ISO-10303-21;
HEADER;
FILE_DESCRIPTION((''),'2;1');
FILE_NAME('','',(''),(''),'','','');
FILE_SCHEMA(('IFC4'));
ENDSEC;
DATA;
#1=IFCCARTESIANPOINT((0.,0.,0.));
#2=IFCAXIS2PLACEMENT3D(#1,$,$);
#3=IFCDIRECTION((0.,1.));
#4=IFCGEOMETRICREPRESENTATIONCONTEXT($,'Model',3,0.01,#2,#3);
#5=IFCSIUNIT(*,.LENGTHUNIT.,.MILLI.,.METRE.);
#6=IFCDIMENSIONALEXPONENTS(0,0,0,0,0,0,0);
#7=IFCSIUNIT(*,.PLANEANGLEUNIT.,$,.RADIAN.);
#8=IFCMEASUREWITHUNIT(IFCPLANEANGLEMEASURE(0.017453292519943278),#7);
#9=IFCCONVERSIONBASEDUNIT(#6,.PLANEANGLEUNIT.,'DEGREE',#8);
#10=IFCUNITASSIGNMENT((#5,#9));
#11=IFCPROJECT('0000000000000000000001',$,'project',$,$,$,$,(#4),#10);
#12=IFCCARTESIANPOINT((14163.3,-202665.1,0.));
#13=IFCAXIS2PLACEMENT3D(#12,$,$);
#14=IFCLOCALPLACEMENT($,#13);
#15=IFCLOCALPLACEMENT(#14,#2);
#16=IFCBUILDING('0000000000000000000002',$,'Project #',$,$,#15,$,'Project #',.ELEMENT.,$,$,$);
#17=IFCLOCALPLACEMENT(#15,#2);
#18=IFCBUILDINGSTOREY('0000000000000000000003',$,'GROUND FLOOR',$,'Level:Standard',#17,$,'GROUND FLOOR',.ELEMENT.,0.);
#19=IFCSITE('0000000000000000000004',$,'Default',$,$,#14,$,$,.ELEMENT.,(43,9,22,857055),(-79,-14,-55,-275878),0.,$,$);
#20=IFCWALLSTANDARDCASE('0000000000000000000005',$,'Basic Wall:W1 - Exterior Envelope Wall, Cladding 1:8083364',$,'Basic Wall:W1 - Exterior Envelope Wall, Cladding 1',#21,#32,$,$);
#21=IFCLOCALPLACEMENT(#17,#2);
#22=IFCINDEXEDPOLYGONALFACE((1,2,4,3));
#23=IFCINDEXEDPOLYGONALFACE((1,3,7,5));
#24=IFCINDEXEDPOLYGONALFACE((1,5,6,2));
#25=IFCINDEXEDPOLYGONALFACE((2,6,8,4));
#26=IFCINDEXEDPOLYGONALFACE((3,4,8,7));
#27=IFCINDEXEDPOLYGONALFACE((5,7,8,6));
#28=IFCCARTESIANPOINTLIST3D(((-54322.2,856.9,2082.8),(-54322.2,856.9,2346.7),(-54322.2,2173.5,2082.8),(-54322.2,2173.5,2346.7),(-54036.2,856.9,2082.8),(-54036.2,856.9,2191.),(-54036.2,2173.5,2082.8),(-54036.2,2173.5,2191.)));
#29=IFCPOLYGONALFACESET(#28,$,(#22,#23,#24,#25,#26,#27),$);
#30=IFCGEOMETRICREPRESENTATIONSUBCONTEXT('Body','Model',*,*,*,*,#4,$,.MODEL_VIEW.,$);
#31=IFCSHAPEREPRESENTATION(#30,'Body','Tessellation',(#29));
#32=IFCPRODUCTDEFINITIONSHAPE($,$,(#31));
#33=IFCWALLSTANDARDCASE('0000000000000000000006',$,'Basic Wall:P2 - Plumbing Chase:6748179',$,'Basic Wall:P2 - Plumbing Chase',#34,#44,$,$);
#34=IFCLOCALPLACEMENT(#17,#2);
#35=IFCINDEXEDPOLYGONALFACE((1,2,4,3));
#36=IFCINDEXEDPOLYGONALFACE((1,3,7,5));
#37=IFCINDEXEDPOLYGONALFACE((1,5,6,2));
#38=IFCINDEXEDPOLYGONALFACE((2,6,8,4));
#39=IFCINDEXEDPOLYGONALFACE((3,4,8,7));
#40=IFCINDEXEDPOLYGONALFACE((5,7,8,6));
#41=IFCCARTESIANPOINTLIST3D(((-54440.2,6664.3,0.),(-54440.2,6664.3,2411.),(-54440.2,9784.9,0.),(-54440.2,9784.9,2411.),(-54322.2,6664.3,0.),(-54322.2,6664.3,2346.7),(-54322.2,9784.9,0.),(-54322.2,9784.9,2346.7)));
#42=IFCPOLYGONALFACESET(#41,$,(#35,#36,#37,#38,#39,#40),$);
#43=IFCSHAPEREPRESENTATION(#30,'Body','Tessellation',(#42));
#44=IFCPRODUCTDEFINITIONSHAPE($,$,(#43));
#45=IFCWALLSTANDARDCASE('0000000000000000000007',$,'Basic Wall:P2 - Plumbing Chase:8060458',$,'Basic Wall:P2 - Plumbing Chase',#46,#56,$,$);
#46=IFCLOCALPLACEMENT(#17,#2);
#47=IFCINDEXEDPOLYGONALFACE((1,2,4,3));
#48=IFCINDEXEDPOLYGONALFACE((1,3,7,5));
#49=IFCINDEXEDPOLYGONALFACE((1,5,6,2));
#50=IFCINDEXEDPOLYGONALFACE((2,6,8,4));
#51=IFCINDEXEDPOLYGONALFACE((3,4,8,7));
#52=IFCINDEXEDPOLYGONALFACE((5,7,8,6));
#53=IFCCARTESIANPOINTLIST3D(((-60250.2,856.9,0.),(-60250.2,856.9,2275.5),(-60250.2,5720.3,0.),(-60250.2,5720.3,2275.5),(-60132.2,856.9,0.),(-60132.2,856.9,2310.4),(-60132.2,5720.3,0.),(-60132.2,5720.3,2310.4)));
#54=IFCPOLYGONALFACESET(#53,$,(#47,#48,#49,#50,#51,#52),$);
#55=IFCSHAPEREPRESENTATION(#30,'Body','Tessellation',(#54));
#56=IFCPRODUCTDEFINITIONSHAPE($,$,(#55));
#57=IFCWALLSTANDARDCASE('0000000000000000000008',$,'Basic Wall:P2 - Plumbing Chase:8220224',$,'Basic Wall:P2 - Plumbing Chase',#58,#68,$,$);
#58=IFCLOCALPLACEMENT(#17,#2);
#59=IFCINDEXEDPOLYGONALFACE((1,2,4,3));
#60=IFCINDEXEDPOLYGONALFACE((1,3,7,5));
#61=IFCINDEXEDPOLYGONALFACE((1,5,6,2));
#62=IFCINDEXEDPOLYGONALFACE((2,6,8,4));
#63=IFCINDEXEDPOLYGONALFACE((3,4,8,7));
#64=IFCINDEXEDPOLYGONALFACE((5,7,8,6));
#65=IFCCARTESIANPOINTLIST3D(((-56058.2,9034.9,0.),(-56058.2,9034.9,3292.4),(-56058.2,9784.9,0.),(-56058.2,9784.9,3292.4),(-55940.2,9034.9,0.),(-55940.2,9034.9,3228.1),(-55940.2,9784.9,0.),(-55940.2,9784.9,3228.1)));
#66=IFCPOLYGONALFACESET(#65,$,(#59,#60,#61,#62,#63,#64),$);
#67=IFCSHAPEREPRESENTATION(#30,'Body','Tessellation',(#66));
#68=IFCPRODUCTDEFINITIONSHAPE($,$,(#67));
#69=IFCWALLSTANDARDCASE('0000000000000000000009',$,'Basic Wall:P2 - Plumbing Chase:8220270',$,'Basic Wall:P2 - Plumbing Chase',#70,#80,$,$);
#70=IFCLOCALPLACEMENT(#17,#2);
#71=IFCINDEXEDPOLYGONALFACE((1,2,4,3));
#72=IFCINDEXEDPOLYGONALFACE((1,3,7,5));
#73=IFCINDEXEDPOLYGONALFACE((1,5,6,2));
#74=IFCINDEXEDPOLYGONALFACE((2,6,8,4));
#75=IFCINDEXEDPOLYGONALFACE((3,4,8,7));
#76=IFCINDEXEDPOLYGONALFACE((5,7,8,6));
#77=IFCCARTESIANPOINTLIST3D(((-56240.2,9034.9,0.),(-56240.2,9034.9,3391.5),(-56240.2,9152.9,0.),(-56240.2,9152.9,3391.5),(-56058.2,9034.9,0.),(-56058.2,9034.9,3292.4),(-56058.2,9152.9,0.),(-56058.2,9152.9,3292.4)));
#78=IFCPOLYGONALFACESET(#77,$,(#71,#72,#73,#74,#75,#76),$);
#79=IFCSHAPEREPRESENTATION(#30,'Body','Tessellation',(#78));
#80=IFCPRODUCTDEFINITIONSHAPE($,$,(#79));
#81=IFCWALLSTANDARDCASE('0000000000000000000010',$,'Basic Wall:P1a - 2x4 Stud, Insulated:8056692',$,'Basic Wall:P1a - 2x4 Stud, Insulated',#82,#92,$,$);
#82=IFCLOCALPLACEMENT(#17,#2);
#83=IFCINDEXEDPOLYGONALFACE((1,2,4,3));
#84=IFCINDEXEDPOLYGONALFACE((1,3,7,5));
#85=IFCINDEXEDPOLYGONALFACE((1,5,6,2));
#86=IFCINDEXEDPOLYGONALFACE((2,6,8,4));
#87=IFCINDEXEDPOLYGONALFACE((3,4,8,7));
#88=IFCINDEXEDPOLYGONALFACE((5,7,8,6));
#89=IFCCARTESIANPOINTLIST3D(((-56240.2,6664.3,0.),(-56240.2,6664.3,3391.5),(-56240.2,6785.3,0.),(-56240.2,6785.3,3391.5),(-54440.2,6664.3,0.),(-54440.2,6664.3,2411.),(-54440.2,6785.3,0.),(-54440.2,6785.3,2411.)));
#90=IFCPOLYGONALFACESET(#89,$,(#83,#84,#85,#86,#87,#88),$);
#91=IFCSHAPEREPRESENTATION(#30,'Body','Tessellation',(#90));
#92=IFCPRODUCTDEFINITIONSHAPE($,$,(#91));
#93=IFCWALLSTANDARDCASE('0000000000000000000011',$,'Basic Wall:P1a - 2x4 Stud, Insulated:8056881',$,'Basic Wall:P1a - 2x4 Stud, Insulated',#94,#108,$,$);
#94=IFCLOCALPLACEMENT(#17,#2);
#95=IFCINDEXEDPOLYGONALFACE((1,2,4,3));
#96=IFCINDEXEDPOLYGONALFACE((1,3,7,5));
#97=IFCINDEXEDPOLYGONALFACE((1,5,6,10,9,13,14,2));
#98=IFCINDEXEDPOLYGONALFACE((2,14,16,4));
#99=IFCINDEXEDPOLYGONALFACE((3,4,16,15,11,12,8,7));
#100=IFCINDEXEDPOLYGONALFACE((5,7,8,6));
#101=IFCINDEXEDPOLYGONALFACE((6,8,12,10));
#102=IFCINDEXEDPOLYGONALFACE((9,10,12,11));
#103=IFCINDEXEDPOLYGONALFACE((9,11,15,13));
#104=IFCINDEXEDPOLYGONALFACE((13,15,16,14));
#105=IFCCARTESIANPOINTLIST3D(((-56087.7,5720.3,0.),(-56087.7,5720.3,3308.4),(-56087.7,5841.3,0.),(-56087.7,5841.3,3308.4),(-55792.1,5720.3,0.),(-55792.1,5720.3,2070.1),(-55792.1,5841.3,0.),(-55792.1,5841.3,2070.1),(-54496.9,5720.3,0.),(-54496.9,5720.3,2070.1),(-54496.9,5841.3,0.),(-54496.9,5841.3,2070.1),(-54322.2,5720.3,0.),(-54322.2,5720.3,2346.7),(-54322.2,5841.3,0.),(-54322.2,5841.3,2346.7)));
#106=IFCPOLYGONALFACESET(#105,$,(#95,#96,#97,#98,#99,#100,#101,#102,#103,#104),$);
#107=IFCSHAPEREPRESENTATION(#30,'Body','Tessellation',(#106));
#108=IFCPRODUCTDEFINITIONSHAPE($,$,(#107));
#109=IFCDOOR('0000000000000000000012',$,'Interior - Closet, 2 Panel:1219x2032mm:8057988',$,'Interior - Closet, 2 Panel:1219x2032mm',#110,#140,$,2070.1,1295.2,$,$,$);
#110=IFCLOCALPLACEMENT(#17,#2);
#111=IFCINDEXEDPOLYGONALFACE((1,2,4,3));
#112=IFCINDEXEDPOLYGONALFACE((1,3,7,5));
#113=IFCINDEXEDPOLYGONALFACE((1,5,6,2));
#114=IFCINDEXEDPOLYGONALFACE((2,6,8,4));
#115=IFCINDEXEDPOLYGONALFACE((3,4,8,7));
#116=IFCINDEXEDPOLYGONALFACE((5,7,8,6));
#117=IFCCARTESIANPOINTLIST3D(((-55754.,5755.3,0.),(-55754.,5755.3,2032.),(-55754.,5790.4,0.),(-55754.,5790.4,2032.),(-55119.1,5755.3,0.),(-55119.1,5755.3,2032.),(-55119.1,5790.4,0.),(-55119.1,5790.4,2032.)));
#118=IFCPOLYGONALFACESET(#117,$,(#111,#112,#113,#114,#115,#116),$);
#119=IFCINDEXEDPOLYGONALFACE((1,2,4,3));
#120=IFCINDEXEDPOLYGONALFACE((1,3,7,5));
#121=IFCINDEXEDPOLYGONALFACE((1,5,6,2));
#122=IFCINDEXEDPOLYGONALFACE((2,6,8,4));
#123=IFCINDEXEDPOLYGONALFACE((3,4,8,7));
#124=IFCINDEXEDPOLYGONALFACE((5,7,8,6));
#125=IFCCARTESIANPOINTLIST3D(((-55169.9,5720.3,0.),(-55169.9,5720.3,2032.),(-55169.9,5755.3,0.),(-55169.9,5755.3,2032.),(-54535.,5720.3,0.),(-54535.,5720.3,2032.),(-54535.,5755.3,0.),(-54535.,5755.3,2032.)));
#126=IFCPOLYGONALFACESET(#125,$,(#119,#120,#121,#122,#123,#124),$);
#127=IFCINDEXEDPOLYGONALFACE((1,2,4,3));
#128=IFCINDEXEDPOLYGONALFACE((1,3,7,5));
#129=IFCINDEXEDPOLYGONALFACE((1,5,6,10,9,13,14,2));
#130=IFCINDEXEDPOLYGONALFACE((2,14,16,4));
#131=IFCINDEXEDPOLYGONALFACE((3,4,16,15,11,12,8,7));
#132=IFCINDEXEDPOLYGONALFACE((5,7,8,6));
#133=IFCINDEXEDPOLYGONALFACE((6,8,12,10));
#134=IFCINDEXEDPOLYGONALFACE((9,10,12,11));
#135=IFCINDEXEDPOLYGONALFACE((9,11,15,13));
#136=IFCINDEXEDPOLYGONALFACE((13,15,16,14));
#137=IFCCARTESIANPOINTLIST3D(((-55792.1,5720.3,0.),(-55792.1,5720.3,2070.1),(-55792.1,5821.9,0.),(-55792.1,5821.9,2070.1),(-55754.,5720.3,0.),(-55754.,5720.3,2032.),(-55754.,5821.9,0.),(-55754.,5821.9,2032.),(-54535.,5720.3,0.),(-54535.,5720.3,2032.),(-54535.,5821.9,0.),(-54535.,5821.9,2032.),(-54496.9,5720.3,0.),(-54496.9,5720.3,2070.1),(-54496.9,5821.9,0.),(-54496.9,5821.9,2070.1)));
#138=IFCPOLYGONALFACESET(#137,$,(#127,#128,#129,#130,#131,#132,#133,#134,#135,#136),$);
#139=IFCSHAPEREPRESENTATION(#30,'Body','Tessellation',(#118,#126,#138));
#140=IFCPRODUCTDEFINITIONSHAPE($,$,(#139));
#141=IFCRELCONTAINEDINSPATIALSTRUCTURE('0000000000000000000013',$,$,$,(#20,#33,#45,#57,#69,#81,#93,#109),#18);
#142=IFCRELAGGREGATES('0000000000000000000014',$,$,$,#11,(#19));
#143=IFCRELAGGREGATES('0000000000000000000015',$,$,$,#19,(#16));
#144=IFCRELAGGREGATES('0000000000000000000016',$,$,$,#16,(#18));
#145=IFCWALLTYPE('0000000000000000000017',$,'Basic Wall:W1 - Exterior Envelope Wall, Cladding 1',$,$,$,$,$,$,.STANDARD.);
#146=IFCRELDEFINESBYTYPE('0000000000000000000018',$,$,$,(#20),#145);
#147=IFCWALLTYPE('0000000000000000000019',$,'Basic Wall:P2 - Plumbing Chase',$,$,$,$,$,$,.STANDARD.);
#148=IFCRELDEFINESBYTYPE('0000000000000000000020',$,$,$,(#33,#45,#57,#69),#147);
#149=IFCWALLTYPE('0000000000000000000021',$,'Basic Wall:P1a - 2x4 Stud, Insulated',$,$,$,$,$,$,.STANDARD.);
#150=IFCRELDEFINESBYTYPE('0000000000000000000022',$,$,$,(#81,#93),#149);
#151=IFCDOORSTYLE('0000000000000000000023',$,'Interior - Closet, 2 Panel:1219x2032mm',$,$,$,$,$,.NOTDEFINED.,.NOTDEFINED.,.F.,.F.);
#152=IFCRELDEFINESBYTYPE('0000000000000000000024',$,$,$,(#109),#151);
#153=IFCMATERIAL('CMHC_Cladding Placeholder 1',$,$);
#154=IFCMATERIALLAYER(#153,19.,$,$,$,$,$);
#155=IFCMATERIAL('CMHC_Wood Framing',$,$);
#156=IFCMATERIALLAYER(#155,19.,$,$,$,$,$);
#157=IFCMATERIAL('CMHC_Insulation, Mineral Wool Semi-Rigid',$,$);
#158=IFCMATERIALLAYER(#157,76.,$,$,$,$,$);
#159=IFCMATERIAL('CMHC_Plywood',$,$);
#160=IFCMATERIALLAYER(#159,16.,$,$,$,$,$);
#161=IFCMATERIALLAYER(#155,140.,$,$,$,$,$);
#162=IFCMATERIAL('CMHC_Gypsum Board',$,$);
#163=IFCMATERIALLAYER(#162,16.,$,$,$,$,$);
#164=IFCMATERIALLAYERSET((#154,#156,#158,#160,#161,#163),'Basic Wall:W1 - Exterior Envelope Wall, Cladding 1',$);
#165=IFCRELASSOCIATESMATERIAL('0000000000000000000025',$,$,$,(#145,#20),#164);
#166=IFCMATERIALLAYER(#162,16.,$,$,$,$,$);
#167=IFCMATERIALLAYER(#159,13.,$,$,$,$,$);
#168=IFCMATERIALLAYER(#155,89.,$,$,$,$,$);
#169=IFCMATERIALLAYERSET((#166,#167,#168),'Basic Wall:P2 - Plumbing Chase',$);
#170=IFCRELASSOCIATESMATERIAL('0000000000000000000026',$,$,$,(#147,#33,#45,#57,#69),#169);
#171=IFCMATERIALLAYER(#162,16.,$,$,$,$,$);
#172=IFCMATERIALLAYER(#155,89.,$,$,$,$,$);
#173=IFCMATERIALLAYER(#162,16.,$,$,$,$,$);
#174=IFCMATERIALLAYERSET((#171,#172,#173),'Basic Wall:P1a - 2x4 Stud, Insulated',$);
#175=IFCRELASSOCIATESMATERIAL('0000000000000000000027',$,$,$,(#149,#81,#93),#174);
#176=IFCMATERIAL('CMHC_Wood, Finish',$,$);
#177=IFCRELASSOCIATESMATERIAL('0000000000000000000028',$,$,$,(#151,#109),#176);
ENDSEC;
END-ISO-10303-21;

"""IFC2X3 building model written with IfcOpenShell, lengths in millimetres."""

from ifc_helpers import new_model, entity, si_unit, converted_unit, direction, frame, frame_2d, origin, place, context, subcontext, project, spatial, polyline, rectangle, outline, extrude, clip, bounded_halfspace, source, transform, mapped, material, layer, layer_set, layer_usage, type_object, type_shapes, element, fill, save


model = new_model("IFC2X3")

# Units and contexts
model_context = context("Model", 3, precision=0.01, world=origin(), true_north=direction((0.0, 1.0)))
body_context = subcontext(model_context, "Body", "Model", "MODEL_VIEW")
ifc_project = project(units=[si_unit("LENGTHUNIT", "METRE", prefix="MILLI"), converted_unit("PLANEANGLEUNIT", "DEGREE", entity("IfcPlaneAngleMeasure", 0.017453292519943278), si_unit("PLANEANGLEUNIT", "RADIAN"), dimensions=[0, 0, 0, 0, 0, 0, 0])], contexts=[model_context])

# Site, building, storey
site_placement = place(None, frame((14163.3, -202665.1, 0.0)))
site = spatial("IfcSite", under=ifc_project, at=site_placement, Name="Default", CompositionType="ELEMENT", RefLatitude=(43, 9, 22, 857055), RefLongitude=(-79, -14, -55, -275878), RefElevation=0.0)
building_placement = place(site_placement, origin())
building = spatial("IfcBuilding", under=site, at=building_placement, Name="Project #", LongName="Project #", CompositionType="ELEMENT")
storey_placement = place(building_placement, origin())
storey = spatial("IfcBuildingStorey", under=building, at=storey_placement, Name="GROUND FLOOR", ObjectType="Level:Standard", LongName="GROUND FLOOR", CompositionType="ELEMENT", Elevation=0.0)

# Shared definitions
ifc_material_1 = material(Name="CMHC_Cladding Placeholder 1")
ifc_layer_1 = layer(ifc_material_1, 19.0)
ifc_material_2 = material(Name="CMHC_Wood Framing")
ifc_layer_2 = layer(ifc_material_2, 19.0)
ifc_material_3 = material(Name="CMHC_Insulation, Mineral Wool Semi-Rigid")
ifc_layer_3 = layer(ifc_material_3, 76.0)
ifc_material_4 = material(Name="CMHC_Plywood")
ifc_layer_4 = layer(ifc_material_4, 16.0)
ifc_layer_5 = layer(ifc_material_2, 140.0)
ifc_material_5 = material(Name="CMHC_Gypsum Board")
ifc_layer_6 = layer(ifc_material_5, 16.0)
ifc_layer_set_1 = layer_set([ifc_layer_1, ifc_layer_2, ifc_layer_3, ifc_layer_4, ifc_layer_5, ifc_layer_6], Name="Basic Wall:W1 - Exterior Envelope Wall, Cladding 1")
wall_type_1 = type_object("IfcWallType", Name="Basic Wall:W1 - Exterior Envelope Wall, Cladding 1", PredefinedType="STANDARD", material=ifc_layer_set_1)

# Walls
ifc_layer_usage_1 = layer_usage(ifc_layer_set_1, "AXIS2", "POSITIVE", -143.0)
wall_1_placement = place(storey_placement, frame((-54179.2, 856.9, 2082.8), z_axis=(0.0, 0.0, 1.0), x_axis=(0.0, 1.0, 0.0)))
element("IfcWallStandardCase", 1, at=wall_1_placement, inside=storey, type_object=wall_type_1, material=ifc_layer_usage_1, Name="Basic Wall:W1 - Exterior Envelope Wall, Cladding 1:8083364", ObjectType="Basic Wall:W1 - Exterior Envelope Wall, Cladding 1", context=body_context, shape_type="Clipping", body=[
    clip(extrude(rectangle(XDim=1316.6, YDim=286.0, at=frame_2d((658.3, 0.0), x_axis=(-1.0, 0.0))), origin(), (0.0, 0.0, 1.0), 263.9), bounded_halfspace(frame((0.0, -143.0, 108.2), z_axis=(0.0, -0.478352, 0.878168), x_axis=(1.0, 0.0, 0.0)), False, frame((0.0, -143.0, 108.2)), polyline([(0.0, 0.0), (1316.6, 0.0), (1316.6, 286.0), (0.0, 286.0), (0.0, 0.0)]))),
])
ifc_layer_7 = layer(ifc_material_5, 16.0)
ifc_layer_8 = layer(ifc_material_4, 13.0)
ifc_layer_9 = layer(ifc_material_2, 89.0)
ifc_layer_set_2 = layer_set([ifc_layer_7, ifc_layer_8, ifc_layer_9], Name="Basic Wall:P2 - Plumbing Chase")
ifc_layer_usage_2 = layer_usage(ifc_layer_set_2, "AXIS2", "POSITIVE", -59.0)
wall_type_2 = type_object("IfcWallType", Name="Basic Wall:P2 - Plumbing Chase", PredefinedType="STANDARD", material=ifc_layer_set_2)
wall_2_placement = place(storey_placement, frame((-54381.2, 9784.9, 0.0), z_axis=(0.0, 0.0, 1.0), x_axis=(0.0, -1.0, 0.0)))
element("IfcWallStandardCase", 2, at=wall_2_placement, inside=storey, type_object=wall_type_2, material=ifc_layer_usage_2, Name="Basic Wall:P2 - Plumbing Chase:6748179", ObjectType="Basic Wall:P2 - Plumbing Chase", context=body_context, shape_type="Clipping", body=[
    clip(extrude(rectangle(XDim=3120.6, YDim=118.0, at=frame_2d((1560.3, 0.0), x_axis=(-1.0, 0.0))), origin(), (0.0, 0.0, 1.0), 2411.0), bounded_halfspace(frame((0.0, -59.0, 2411.0), z_axis=(0.0, 0.478352, 0.878168), x_axis=(-1.0, 0.0, 0.0)), False, frame((0.0, -59.0, 2411.0)), polyline([(0.0, 0.0), (2999.6, 0.0), (3120.6, 0.0), (3120.6, 118.0), (0.0, 118.0), (0.0, 0.0)]))),
])
ifc_layer_usage_3 = layer_usage(ifc_layer_set_2, "AXIS2", "NEGATIVE", 59.0)
wall_3_placement = place(storey_placement, frame((-60191.2, 5720.3, 0.0), z_axis=(0.0, 0.0, 1.0), x_axis=(0.0, -1.0, 0.0)))
element("IfcWallStandardCase", 3, at=wall_3_placement, inside=storey, type_object=wall_type_2, material=ifc_layer_usage_3, Name="Basic Wall:P2 - Plumbing Chase:8060458", ObjectType="Basic Wall:P2 - Plumbing Chase", context=body_context, shape_type="Clipping", body=[
    clip(extrude(rectangle(XDim=4863.4, YDim=118.0, at=frame_2d((2431.7, 0.0), x_axis=(-1.0, 0.0))), origin(), (0.0, 0.0, 1.0), 2310.4), bounded_halfspace(frame((0.0, -59.0, 2275.5), z_axis=(0.0, -0.283519, 0.958967), x_axis=(1.0, 0.0, 0.0)), False, frame((0.0, -59.0, 2275.5)), polyline([(0.0, 0.0), (4863.4, 0.0), (4863.4, 118.0), (0.0, 118.0), (0.0, 0.0)]))),
])
ifc_layer_usage_4 = layer_usage(ifc_layer_set_2, "AXIS2", "POSITIVE", -59.0)
wall_4_placement = place(storey_placement, frame((-55999.2, 9034.9, 0.0), z_axis=(0.0, 0.0, 1.0), x_axis=(0.0, 1.0, 0.0)))
element("IfcWallStandardCase", 4, at=wall_4_placement, inside=storey, type_object=wall_type_2, material=ifc_layer_usage_4, Name="Basic Wall:P2 - Plumbing Chase:8220224", ObjectType="Basic Wall:P2 - Plumbing Chase", context=body_context, shape_type="Clipping", body=[
    clip(extrude(rectangle(XDim=750.0, YDim=118.0, at=frame_2d((375.0, 0.0), x_axis=(-1.0, 0.0))), origin(), (0.0, 0.0, 1.0), 3292.4), bounded_halfspace(frame((0.0, -59.0, 3228.1), z_axis=(0.0, -0.478352, 0.878168), x_axis=(1.0, 0.0, 0.0)), False, frame((0.0, -59.0, 3228.1)), polyline([(0.0, 0.0), (750.0, 0.0), (750.0, 118.0), (118.0, 118.0), (0.0, 118.0), (0.0, 0.0)]))),
])
ifc_layer_usage_5 = layer_usage(ifc_layer_set_2, "AXIS2", "NEGATIVE", 59.0)
wall_5_placement = place(storey_placement, frame((-56058.2, 9093.9, 0.0), z_axis=(0.0, 0.0, 1.0), x_axis=(-1.0, 0.0, 0.0)))
element("IfcWallStandardCase", 5, at=wall_5_placement, inside=storey, type_object=wall_type_2, material=ifc_layer_usage_5, Name="Basic Wall:P2 - Plumbing Chase:8220270", ObjectType="Basic Wall:P2 - Plumbing Chase", context=body_context, shape_type="Clipping", body=[
    clip(extrude(rectangle(XDim=182.0, YDim=118.0, at=frame_2d((91.0, 0.0), x_axis=(-1.0, 0.0))), origin(), (0.0, 0.0, 1.0), 3391.5), bounded_halfspace(frame((0.0, -59.0, 3292.4), z_axis=(-0.478352, 0.0, 0.878168), x_axis=(0.0, -1.0, 0.0)), False, frame((0.0, -59.0, 3292.4)), polyline([(0.0, 0.0), (182.0, 0.0), (182.0, 118.0), (0.0, 118.0), (0.0, 0.0)]))),
])
ifc_layer_10 = layer(ifc_material_5, 16.0)
ifc_layer_11 = layer(ifc_material_2, 89.0)
ifc_layer_12 = layer(ifc_material_5, 16.0)
ifc_layer_set_3 = layer_set([ifc_layer_10, ifc_layer_11, ifc_layer_12], Name="Basic Wall:P1a - 2x4 Stud, Insulated")
ifc_layer_usage_6 = layer_usage(ifc_layer_set_3, "AXIS2", "POSITIVE", -60.5)
wall_type_3 = type_object("IfcWallType", Name="Basic Wall:P1a - 2x4 Stud, Insulated", PredefinedType="STANDARD", material=ifc_layer_set_3)
wall_6_placement = place(storey_placement, frame((-54440.2, 6724.8, 0.0), z_axis=(0.0, 0.0, 1.0), x_axis=(-1.0, 0.0, 0.0)))
element("IfcWallStandardCase", 6, at=wall_6_placement, inside=storey, type_object=wall_type_3, material=ifc_layer_usage_6, Name="Basic Wall:P1a - 2x4 Stud, Insulated:8056692", ObjectType="Basic Wall:P1a - 2x4 Stud, Insulated", context=body_context, shape_type="Clipping", body=[
    clip(extrude(rectangle(XDim=1800.0, YDim=121.0, at=frame_2d((900.0, 0.0), x_axis=(-1.0, 0.0))), origin(), (0.0, 0.0, 1.0), 3391.5), bounded_halfspace(frame((0.0, -60.5, 2411.0), z_axis=(-0.478352, 0.0, 0.878168), x_axis=(0.0, -1.0, 0.0)), False, frame((0.0, -60.5, 2411.0)), polyline([(0.0, 0.0), (1800.0, 0.0), (1800.0, 54.8), (1800.0, 121.0), (1647.5, 121.0), (1526.5, 121.0), (0.0, 121.0), (0.0, 0.0)]))),
])

# Wall, opening, door
ifc_layer_usage_7 = layer_usage(ifc_layer_set_3, "AXIS2", "POSITIVE", -60.5)
wall_7_placement = place(storey_placement, frame((-54322.2, 5780.8, 0.0), z_axis=(0.0, 0.0, 1.0), x_axis=(-1.0, 0.0, 0.0)))
wall_7 = element("IfcWallStandardCase", 7, at=wall_7_placement, inside=storey, type_object=wall_type_3, material=ifc_layer_usage_7, Name="Basic Wall:P1a - 2x4 Stud, Insulated:8056881", ObjectType="Basic Wall:P1a - 2x4 Stud, Insulated", context=body_context, shape_type="Clipping", body=[
    clip(extrude(rectangle(XDim=1765.5, YDim=121.0, at=frame_2d((882.8, 0.0), x_axis=(1.0, 0.0))), origin(), (0.0, 0.0, 1.0), 3308.4), bounded_halfspace(frame((0.0, -60.5, 2346.7), z_axis=(-0.478352, 0.0, 0.878168), x_axis=(0.0, -1.0, 0.0)), False, frame((0.0, -60.5, 2346.7)), polyline([(0.0, 0.0), (1644.5, 0.0), (1765.5, 0.0), (1765.5, 121.0), (0.0, 121.0), (0.0, 0.0)]))),
])
opening_1_placement = place(wall_7_placement, frame((174.6, -60.5, 0.0)))
opening_1 = element("IfcOpeningElement", 8, at=opening_1_placement, cuts=wall_7, ObjectType="Opening", context=body_context, shape_type="SweptSolid", body=[
    extrude(rectangle(XDim=1295.2, YDim=2070.1, at=frame_2d((1035.0, 647.6), x_axis=(0.0, 1.0))), frame((0.0, 0.0, 0.0), z_axis=(0.0, 1.0, 0.0), x_axis=(0.0, 0.0, 1.0)), (0.0, 0.0, 1.0), 121.0),
])
ifc_material_6 = material(Name="CMHC_Wood, Finish")
door_style_1 = type_object("IfcDoorStyle", Name="Interior - Closet, 2 Panel:1219x2032mm", ConstructionType="NOTDEFINED", OperationType="NOTDEFINED", ParameterTakesPrecedence=False, Sizeable=False, material=ifc_material_6)
shared_shape_1 = source(origin(), body_context, "Body", "SweptSolid", [
    extrude(rectangle(XDim=35.0, YDim=634.9, at=frame_2d((0.0, 0.0), x_axis=(1.0, 0.0))), frame((939.6, 68.5, 0.0), z_axis=(0.0, 0.0, 1.0), x_axis=(0.0, 1.0, 0.0)), (0.0, 0.0, 1.0), 2032.0),
    extrude(rectangle(XDim=35.0, YDim=634.9, at=frame_2d((0.0, 0.0), x_axis=(1.0, 0.0))), frame((355.5, 103.5, 0.0), z_axis=(0.0, 0.0, 1.0), x_axis=(0.0, 1.0, 0.0)), (0.0, 0.0, 1.0), 2032.0),
    extrude(outline(polyline([(609.5, -1025.5), (647.6, -1025.5), (647.6, 1044.6), (-647.6, 1044.6), (-647.6, -1025.5), (-609.5, -1025.5), (-609.5, 1006.5), (609.5, 1006.5), (609.5, -1025.5)])), frame((647.6, 19.4, 1025.5), z_axis=(0.0, 1.0, 0.0), x_axis=(-1.0, 0.0, 0.0)), (0.0, 0.0, 1.0), 101.6),
])
type_shapes(door_style_1, [shared_shape_1])
door_1_placement = place(opening_1_placement, origin())
door_1 = element("IfcDoor", 9, at=door_1_placement, inside=storey, type_object=door_style_1, material=ifc_material_6, Name="Interior - Closet, 2 Panel:1219x2032mm:8057988", ObjectType="Interior - Closet, 2 Panel:1219x2032mm", OverallHeight=2070.1, OverallWidth=1295.2, context=body_context, shape_type="MappedRepresentation", body=[
    mapped(shared_shape_1, transform((0.0, 0.0, 0.0), scale=1.0)),
])
fill(opening_1, door_1)

save(model, "model.ifc")
